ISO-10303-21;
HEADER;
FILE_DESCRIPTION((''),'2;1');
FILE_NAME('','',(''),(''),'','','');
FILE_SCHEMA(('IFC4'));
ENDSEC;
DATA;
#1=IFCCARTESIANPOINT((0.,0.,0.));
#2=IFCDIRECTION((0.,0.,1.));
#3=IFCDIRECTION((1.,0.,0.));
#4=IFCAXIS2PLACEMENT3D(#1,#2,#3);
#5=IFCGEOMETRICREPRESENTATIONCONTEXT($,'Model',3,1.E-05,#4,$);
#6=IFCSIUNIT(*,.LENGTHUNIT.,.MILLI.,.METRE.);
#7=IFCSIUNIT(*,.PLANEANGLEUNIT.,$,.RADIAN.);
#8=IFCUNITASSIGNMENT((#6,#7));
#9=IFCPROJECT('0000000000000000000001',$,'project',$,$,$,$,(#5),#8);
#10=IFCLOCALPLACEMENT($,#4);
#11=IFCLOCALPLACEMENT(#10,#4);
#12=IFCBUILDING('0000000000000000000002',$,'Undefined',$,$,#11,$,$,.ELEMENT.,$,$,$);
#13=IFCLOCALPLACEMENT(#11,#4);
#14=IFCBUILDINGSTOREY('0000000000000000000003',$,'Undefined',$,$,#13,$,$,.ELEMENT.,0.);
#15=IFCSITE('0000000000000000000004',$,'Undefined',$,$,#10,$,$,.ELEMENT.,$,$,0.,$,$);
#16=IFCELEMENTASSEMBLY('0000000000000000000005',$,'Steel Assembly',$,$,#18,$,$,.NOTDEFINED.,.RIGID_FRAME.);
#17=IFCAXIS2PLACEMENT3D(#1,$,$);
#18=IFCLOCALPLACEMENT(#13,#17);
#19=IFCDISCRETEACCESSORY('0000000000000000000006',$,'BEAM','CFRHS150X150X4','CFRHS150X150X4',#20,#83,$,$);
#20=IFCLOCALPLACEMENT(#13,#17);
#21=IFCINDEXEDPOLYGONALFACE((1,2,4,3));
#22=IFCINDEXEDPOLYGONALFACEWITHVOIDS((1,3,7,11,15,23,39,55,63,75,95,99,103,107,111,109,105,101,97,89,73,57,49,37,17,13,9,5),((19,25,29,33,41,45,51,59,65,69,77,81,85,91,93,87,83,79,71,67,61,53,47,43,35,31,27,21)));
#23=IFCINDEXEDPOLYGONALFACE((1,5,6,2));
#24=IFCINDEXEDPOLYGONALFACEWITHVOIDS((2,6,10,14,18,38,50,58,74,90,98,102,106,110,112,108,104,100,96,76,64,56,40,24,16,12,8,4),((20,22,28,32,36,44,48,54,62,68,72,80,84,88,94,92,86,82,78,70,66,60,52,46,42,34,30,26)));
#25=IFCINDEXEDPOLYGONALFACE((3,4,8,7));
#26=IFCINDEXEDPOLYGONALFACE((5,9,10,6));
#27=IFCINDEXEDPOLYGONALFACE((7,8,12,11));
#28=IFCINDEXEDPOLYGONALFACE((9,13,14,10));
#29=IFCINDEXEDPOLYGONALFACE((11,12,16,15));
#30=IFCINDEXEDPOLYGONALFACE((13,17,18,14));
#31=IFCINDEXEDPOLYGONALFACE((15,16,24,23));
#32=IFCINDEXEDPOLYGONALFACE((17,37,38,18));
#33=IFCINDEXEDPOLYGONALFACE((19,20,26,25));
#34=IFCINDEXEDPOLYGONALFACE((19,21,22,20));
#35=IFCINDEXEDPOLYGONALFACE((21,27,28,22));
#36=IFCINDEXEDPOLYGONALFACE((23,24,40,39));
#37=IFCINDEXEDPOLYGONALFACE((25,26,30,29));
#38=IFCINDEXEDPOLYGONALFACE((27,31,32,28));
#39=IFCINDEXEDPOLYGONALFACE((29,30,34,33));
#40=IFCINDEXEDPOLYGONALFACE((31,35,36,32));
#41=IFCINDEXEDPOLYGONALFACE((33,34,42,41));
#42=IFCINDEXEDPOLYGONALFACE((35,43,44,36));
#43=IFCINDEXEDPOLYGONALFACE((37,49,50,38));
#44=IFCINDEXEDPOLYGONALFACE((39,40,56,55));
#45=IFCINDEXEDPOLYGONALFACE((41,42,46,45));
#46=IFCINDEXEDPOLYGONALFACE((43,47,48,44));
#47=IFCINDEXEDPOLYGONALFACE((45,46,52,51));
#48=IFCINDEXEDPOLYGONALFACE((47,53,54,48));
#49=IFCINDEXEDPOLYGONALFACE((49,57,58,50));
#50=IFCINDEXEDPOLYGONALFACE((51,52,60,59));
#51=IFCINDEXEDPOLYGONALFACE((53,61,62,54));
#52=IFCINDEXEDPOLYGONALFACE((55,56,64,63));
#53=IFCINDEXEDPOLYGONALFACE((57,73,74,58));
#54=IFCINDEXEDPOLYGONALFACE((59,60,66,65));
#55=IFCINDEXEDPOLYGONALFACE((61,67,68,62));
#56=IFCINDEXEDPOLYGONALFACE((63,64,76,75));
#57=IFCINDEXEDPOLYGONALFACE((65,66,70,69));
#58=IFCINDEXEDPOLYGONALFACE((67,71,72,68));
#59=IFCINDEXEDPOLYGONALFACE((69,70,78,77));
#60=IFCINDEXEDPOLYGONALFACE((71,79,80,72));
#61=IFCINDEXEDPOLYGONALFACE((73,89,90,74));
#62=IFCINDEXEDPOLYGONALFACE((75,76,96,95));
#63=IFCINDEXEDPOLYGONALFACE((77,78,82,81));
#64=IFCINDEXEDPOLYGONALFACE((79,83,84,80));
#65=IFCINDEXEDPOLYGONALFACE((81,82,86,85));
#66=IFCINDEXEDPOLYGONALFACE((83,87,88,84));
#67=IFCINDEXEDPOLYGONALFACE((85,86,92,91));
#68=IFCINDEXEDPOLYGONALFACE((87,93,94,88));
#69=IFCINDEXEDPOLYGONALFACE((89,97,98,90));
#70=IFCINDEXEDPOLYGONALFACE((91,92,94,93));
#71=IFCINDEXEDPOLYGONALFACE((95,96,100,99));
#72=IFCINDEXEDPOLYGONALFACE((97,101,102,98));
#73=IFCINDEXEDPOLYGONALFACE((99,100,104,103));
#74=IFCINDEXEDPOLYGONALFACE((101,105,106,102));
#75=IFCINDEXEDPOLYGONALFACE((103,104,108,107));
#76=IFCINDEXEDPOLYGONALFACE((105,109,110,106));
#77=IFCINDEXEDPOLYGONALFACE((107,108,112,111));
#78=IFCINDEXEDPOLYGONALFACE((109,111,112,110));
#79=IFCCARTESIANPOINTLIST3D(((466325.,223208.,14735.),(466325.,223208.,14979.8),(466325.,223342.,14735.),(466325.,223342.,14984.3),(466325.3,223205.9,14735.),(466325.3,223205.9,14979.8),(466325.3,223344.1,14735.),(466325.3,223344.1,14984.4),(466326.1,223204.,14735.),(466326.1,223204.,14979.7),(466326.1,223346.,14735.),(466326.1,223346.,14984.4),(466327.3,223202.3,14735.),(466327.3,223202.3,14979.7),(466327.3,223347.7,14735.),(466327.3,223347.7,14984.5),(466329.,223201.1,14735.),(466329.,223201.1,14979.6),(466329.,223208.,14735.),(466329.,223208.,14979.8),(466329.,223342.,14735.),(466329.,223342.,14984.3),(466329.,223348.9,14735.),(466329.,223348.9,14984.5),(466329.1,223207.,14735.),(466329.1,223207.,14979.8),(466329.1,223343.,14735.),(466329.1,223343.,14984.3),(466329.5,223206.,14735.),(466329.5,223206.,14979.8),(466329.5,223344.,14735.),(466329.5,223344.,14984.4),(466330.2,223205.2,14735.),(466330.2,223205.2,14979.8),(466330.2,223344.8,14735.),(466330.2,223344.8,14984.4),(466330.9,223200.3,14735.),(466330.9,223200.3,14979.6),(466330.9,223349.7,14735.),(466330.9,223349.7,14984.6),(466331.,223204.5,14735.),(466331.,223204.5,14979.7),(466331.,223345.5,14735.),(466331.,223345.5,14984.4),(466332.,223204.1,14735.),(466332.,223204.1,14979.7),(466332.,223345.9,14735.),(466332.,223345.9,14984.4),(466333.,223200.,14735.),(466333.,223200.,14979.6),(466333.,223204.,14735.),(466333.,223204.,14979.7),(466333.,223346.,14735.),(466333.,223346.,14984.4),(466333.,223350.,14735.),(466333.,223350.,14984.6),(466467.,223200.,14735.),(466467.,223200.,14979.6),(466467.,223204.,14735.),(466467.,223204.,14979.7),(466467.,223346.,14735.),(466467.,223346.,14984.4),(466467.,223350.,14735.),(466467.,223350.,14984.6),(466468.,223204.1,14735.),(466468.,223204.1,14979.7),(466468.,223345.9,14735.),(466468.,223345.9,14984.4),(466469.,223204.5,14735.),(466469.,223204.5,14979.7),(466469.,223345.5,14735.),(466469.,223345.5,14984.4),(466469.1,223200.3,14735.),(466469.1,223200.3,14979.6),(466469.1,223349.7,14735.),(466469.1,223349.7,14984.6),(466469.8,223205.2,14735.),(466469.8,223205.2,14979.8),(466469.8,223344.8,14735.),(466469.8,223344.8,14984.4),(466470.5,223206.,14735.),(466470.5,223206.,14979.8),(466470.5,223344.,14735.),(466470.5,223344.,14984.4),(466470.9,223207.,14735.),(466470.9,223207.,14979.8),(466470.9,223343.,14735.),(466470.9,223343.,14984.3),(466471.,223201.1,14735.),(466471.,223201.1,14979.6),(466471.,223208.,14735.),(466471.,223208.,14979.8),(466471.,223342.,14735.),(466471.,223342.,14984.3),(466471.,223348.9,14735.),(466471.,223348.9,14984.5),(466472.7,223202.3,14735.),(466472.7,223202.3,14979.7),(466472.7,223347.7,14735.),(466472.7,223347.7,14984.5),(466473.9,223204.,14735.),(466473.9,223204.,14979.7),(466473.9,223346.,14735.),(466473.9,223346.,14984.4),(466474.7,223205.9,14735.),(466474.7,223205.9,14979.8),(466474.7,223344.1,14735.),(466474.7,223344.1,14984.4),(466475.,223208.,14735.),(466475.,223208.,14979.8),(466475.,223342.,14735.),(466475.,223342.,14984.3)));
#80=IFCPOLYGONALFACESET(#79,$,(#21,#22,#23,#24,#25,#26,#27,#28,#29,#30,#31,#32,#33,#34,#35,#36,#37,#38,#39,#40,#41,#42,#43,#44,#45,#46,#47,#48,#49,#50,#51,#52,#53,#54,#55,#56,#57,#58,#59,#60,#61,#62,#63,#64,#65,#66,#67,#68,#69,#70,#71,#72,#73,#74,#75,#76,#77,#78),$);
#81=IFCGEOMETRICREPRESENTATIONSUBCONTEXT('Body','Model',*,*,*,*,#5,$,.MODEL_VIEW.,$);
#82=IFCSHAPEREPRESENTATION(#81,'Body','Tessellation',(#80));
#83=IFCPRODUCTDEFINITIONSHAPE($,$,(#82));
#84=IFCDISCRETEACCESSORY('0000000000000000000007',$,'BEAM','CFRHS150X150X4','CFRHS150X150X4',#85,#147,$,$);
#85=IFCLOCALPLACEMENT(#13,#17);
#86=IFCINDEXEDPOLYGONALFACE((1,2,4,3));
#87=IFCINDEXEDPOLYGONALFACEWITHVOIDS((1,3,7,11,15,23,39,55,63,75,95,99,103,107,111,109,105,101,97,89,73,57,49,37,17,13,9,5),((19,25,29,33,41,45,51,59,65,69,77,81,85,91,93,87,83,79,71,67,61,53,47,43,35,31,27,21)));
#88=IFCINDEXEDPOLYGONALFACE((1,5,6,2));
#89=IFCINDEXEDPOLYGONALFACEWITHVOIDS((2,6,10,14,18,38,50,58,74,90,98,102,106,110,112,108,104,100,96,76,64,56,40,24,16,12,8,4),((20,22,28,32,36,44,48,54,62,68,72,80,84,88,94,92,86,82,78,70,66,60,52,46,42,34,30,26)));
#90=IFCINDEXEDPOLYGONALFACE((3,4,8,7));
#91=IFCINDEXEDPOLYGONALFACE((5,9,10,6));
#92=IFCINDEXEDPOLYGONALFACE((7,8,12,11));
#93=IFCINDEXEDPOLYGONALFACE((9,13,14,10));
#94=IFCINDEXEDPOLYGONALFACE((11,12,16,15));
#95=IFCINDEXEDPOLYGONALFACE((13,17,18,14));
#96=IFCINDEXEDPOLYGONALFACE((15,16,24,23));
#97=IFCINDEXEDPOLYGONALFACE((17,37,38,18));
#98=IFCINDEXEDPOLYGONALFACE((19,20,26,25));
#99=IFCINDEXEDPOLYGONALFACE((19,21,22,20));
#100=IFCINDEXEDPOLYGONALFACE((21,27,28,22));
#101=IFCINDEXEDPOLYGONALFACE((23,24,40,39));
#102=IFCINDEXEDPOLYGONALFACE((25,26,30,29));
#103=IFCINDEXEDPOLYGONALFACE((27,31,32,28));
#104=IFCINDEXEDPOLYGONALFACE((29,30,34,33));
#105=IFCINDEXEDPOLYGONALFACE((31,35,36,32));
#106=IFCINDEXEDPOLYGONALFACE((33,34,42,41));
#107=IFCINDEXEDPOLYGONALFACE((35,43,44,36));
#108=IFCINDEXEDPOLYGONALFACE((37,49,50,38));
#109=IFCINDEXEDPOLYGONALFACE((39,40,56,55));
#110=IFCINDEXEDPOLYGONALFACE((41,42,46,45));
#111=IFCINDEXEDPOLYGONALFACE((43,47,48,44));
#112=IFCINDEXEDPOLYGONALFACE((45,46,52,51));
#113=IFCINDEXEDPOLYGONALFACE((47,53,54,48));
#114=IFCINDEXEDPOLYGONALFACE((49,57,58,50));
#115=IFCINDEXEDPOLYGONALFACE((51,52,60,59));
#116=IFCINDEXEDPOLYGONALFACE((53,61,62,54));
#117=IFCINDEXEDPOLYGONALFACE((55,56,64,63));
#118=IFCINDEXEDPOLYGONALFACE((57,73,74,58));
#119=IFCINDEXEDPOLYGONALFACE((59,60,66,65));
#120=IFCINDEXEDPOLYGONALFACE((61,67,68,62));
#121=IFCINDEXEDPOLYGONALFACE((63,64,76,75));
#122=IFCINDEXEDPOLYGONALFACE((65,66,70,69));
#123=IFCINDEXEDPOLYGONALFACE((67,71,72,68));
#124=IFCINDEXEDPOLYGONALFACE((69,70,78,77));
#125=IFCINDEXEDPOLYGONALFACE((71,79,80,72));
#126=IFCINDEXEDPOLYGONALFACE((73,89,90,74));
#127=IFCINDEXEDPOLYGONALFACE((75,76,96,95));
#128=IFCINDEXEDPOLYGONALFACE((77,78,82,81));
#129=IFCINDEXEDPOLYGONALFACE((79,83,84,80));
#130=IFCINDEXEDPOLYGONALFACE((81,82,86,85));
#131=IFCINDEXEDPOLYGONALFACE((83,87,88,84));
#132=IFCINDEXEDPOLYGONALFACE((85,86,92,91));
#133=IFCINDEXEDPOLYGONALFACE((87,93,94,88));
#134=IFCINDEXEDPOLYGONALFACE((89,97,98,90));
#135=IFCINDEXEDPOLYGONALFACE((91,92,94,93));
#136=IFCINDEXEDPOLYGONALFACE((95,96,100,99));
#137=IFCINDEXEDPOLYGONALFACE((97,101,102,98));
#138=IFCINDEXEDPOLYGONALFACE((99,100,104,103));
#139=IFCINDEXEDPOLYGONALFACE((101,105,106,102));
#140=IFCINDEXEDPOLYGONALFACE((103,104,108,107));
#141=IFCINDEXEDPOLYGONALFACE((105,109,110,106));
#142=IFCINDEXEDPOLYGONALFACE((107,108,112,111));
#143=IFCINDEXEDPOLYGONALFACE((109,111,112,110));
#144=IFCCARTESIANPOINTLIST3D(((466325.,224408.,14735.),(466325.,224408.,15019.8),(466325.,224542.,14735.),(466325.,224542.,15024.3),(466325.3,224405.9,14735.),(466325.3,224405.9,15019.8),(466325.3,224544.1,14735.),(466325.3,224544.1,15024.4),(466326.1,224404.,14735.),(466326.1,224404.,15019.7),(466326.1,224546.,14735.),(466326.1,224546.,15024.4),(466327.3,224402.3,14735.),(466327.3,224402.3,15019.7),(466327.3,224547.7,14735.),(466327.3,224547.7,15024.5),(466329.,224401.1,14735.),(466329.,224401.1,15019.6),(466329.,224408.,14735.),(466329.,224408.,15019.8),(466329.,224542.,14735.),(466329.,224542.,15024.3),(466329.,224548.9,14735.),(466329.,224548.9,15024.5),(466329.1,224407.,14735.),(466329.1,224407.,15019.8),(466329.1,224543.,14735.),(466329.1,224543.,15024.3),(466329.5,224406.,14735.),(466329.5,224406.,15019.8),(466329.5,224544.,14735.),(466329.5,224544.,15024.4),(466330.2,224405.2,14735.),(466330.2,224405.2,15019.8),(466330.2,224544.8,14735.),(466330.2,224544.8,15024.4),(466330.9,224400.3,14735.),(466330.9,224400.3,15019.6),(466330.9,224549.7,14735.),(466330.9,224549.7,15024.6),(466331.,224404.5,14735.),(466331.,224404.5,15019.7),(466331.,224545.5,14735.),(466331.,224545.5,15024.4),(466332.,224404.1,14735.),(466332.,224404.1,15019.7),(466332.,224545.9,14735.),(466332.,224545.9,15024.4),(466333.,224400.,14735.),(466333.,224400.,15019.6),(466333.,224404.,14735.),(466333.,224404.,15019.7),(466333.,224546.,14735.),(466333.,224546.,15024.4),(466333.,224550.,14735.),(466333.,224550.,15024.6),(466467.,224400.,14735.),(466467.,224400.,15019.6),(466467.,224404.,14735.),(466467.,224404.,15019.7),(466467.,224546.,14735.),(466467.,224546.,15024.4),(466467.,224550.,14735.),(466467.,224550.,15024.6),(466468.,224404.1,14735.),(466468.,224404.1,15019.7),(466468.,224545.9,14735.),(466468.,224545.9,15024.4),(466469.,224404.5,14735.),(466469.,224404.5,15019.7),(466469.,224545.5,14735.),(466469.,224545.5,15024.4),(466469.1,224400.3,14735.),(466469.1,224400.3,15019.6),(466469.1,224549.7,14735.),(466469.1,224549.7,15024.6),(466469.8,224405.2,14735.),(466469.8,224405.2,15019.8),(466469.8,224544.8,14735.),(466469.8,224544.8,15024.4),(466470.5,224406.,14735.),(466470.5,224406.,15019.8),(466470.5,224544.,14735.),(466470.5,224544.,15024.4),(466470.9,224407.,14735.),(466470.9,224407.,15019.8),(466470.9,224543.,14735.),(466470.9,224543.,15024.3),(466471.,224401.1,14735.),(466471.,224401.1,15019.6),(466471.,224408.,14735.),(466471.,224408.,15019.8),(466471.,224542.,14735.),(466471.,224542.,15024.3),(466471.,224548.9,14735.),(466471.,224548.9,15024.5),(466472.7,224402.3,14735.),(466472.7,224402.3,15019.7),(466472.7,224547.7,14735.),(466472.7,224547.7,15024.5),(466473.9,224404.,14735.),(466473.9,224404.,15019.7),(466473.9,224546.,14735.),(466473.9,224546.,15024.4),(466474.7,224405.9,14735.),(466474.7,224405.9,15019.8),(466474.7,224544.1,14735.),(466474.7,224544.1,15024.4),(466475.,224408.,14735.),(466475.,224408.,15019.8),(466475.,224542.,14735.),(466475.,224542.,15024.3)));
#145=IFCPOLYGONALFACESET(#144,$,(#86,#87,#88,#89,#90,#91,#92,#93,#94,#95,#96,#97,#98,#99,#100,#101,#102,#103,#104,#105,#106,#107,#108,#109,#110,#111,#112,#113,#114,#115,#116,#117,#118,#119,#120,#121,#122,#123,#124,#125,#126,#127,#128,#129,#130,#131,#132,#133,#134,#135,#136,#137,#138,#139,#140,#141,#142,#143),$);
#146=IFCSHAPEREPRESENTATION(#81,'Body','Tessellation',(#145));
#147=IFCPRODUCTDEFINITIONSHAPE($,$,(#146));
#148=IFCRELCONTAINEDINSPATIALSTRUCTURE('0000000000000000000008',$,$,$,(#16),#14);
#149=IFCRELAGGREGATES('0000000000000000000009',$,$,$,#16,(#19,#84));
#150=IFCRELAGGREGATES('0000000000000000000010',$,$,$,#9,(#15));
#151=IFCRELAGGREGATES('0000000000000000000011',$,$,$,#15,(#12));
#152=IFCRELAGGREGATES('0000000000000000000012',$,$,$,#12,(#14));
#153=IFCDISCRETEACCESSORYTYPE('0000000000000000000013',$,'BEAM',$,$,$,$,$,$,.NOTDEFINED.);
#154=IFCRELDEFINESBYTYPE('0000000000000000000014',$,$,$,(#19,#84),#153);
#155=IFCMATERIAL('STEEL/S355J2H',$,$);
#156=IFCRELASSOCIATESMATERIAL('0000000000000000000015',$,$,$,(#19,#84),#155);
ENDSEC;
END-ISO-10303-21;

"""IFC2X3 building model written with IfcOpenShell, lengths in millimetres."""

from ifc_helpers import new_model, si_unit, frame, origin_with_axes, origin_2d_with_axis, place, context, subcontext, project, spatial, hollow_rectangle, extrude, clip, halfspace, material, type_object, element, aggregate, save


model = new_model("IFC2X3")

# Units and contexts
model_context = context("Model", 3, precision=1e-05, world=origin_with_axes())
body_context = subcontext(model_context, "Body", "Model", "MODEL_VIEW")
ifc_project = project(units=[si_unit("LENGTHUNIT", "METRE", prefix="MILLI"), si_unit("PLANEANGLEUNIT", "RADIAN")], contexts=[model_context])

# Site, building, storey
site_placement = place(None, origin_with_axes())
site = spatial("IfcSite", under=ifc_project, at=site_placement, Name="Undefined", CompositionType="ELEMENT", RefElevation=0.0)
building_placement = place(site_placement, origin_with_axes())
building = spatial("IfcBuilding", under=site, at=building_placement, Name="Undefined", CompositionType="ELEMENT")
storey_placement = place(building_placement, origin_with_axes())
storey = spatial("IfcBuildingStorey", under=building, at=storey_placement, Name="Undefined", CompositionType="ELEMENT", Elevation=0.0)

# Shared definitions
ifc_material_1 = material(Name="STEEL/S355J2H")

# Element assembly, discrete accessories
assembly_1_placement = place(storey_placement, origin_with_axes())
assembly_1 = element("IfcElementAssembly", 1, at=assembly_1_placement, inside=storey, Name="Steel Assembly", AssemblyPlace="NOTDEFINED", PredefinedType="RIGID_FRAME")
discrete_accessory_type_1 = type_object("IfcDiscreteAccessoryType", Name="BEAM")
discrete_accessory_1_placement = place(assembly_1_placement, frame((466400.0, 223275.0, 14720.0), z_axis=(0.0, 0.0, 1.0), x_axis=(1.0, 0.0, 0.0)))
discrete_accessory_1 = element("IfcDiscreteAccessory", 2, at=discrete_accessory_1_placement, type_object=discrete_accessory_type_1, material=ifc_material_1, Name="BEAM", Description="CFRHS150X150X4", ObjectType="CFRHS150X150X4", context=body_context, shape_type="Clipping", body=[
    clip(extrude(hollow_rectangle(XDim=150.0, YDim=150.0, WallThickness=4.0, InnerFilletRadius=4.0, OuterFilletRadius=8.0, at=origin_2d_with_axis()), frame((0.0, 0.0, 264.6), z_axis=(0.0, 0.0, -1.0), x_axis=(0.0, -1.0, 0.0)), (0.0, 0.0, 1.0), 249.6), halfspace(frame((-1000.0, 2.7, 262.2), z_axis=(0.0, 0.033315, -0.999445), x_axis=(0.0, -0.999445, -0.033315)), True)),
])
discrete_accessory_2_placement = place(assembly_1_placement, frame((466400.0, 224475.0, 14720.0), z_axis=(0.0, 0.0, 1.0), x_axis=(1.0, 0.0, 0.0)))
discrete_accessory_2 = element("IfcDiscreteAccessory", 3, at=discrete_accessory_2_placement, type_object=discrete_accessory_type_1, material=ifc_material_1, Name="BEAM", Description="CFRHS150X150X4", ObjectType="CFRHS150X150X4", context=body_context, shape_type="Clipping", body=[
    clip(extrude(hollow_rectangle(XDim=150.0, YDim=150.0, WallThickness=4.0, InnerFilletRadius=4.0, OuterFilletRadius=8.0, at=origin_2d_with_axis()), frame((0.0, 0.0, 304.6), z_axis=(0.0, 0.0, -1.0), x_axis=(0.0, -1.0, 0.0)), (0.0, 0.0, 1.0), 289.6), halfspace(frame((-1000.0, 2.7, 302.2), z_axis=(0.0, 0.033315, -0.999445), x_axis=(0.0, -0.999445, -0.033315)), True)),
])
aggregate(assembly_1, [discrete_accessory_1, discrete_accessory_2])

save(model, "model.ifc")
